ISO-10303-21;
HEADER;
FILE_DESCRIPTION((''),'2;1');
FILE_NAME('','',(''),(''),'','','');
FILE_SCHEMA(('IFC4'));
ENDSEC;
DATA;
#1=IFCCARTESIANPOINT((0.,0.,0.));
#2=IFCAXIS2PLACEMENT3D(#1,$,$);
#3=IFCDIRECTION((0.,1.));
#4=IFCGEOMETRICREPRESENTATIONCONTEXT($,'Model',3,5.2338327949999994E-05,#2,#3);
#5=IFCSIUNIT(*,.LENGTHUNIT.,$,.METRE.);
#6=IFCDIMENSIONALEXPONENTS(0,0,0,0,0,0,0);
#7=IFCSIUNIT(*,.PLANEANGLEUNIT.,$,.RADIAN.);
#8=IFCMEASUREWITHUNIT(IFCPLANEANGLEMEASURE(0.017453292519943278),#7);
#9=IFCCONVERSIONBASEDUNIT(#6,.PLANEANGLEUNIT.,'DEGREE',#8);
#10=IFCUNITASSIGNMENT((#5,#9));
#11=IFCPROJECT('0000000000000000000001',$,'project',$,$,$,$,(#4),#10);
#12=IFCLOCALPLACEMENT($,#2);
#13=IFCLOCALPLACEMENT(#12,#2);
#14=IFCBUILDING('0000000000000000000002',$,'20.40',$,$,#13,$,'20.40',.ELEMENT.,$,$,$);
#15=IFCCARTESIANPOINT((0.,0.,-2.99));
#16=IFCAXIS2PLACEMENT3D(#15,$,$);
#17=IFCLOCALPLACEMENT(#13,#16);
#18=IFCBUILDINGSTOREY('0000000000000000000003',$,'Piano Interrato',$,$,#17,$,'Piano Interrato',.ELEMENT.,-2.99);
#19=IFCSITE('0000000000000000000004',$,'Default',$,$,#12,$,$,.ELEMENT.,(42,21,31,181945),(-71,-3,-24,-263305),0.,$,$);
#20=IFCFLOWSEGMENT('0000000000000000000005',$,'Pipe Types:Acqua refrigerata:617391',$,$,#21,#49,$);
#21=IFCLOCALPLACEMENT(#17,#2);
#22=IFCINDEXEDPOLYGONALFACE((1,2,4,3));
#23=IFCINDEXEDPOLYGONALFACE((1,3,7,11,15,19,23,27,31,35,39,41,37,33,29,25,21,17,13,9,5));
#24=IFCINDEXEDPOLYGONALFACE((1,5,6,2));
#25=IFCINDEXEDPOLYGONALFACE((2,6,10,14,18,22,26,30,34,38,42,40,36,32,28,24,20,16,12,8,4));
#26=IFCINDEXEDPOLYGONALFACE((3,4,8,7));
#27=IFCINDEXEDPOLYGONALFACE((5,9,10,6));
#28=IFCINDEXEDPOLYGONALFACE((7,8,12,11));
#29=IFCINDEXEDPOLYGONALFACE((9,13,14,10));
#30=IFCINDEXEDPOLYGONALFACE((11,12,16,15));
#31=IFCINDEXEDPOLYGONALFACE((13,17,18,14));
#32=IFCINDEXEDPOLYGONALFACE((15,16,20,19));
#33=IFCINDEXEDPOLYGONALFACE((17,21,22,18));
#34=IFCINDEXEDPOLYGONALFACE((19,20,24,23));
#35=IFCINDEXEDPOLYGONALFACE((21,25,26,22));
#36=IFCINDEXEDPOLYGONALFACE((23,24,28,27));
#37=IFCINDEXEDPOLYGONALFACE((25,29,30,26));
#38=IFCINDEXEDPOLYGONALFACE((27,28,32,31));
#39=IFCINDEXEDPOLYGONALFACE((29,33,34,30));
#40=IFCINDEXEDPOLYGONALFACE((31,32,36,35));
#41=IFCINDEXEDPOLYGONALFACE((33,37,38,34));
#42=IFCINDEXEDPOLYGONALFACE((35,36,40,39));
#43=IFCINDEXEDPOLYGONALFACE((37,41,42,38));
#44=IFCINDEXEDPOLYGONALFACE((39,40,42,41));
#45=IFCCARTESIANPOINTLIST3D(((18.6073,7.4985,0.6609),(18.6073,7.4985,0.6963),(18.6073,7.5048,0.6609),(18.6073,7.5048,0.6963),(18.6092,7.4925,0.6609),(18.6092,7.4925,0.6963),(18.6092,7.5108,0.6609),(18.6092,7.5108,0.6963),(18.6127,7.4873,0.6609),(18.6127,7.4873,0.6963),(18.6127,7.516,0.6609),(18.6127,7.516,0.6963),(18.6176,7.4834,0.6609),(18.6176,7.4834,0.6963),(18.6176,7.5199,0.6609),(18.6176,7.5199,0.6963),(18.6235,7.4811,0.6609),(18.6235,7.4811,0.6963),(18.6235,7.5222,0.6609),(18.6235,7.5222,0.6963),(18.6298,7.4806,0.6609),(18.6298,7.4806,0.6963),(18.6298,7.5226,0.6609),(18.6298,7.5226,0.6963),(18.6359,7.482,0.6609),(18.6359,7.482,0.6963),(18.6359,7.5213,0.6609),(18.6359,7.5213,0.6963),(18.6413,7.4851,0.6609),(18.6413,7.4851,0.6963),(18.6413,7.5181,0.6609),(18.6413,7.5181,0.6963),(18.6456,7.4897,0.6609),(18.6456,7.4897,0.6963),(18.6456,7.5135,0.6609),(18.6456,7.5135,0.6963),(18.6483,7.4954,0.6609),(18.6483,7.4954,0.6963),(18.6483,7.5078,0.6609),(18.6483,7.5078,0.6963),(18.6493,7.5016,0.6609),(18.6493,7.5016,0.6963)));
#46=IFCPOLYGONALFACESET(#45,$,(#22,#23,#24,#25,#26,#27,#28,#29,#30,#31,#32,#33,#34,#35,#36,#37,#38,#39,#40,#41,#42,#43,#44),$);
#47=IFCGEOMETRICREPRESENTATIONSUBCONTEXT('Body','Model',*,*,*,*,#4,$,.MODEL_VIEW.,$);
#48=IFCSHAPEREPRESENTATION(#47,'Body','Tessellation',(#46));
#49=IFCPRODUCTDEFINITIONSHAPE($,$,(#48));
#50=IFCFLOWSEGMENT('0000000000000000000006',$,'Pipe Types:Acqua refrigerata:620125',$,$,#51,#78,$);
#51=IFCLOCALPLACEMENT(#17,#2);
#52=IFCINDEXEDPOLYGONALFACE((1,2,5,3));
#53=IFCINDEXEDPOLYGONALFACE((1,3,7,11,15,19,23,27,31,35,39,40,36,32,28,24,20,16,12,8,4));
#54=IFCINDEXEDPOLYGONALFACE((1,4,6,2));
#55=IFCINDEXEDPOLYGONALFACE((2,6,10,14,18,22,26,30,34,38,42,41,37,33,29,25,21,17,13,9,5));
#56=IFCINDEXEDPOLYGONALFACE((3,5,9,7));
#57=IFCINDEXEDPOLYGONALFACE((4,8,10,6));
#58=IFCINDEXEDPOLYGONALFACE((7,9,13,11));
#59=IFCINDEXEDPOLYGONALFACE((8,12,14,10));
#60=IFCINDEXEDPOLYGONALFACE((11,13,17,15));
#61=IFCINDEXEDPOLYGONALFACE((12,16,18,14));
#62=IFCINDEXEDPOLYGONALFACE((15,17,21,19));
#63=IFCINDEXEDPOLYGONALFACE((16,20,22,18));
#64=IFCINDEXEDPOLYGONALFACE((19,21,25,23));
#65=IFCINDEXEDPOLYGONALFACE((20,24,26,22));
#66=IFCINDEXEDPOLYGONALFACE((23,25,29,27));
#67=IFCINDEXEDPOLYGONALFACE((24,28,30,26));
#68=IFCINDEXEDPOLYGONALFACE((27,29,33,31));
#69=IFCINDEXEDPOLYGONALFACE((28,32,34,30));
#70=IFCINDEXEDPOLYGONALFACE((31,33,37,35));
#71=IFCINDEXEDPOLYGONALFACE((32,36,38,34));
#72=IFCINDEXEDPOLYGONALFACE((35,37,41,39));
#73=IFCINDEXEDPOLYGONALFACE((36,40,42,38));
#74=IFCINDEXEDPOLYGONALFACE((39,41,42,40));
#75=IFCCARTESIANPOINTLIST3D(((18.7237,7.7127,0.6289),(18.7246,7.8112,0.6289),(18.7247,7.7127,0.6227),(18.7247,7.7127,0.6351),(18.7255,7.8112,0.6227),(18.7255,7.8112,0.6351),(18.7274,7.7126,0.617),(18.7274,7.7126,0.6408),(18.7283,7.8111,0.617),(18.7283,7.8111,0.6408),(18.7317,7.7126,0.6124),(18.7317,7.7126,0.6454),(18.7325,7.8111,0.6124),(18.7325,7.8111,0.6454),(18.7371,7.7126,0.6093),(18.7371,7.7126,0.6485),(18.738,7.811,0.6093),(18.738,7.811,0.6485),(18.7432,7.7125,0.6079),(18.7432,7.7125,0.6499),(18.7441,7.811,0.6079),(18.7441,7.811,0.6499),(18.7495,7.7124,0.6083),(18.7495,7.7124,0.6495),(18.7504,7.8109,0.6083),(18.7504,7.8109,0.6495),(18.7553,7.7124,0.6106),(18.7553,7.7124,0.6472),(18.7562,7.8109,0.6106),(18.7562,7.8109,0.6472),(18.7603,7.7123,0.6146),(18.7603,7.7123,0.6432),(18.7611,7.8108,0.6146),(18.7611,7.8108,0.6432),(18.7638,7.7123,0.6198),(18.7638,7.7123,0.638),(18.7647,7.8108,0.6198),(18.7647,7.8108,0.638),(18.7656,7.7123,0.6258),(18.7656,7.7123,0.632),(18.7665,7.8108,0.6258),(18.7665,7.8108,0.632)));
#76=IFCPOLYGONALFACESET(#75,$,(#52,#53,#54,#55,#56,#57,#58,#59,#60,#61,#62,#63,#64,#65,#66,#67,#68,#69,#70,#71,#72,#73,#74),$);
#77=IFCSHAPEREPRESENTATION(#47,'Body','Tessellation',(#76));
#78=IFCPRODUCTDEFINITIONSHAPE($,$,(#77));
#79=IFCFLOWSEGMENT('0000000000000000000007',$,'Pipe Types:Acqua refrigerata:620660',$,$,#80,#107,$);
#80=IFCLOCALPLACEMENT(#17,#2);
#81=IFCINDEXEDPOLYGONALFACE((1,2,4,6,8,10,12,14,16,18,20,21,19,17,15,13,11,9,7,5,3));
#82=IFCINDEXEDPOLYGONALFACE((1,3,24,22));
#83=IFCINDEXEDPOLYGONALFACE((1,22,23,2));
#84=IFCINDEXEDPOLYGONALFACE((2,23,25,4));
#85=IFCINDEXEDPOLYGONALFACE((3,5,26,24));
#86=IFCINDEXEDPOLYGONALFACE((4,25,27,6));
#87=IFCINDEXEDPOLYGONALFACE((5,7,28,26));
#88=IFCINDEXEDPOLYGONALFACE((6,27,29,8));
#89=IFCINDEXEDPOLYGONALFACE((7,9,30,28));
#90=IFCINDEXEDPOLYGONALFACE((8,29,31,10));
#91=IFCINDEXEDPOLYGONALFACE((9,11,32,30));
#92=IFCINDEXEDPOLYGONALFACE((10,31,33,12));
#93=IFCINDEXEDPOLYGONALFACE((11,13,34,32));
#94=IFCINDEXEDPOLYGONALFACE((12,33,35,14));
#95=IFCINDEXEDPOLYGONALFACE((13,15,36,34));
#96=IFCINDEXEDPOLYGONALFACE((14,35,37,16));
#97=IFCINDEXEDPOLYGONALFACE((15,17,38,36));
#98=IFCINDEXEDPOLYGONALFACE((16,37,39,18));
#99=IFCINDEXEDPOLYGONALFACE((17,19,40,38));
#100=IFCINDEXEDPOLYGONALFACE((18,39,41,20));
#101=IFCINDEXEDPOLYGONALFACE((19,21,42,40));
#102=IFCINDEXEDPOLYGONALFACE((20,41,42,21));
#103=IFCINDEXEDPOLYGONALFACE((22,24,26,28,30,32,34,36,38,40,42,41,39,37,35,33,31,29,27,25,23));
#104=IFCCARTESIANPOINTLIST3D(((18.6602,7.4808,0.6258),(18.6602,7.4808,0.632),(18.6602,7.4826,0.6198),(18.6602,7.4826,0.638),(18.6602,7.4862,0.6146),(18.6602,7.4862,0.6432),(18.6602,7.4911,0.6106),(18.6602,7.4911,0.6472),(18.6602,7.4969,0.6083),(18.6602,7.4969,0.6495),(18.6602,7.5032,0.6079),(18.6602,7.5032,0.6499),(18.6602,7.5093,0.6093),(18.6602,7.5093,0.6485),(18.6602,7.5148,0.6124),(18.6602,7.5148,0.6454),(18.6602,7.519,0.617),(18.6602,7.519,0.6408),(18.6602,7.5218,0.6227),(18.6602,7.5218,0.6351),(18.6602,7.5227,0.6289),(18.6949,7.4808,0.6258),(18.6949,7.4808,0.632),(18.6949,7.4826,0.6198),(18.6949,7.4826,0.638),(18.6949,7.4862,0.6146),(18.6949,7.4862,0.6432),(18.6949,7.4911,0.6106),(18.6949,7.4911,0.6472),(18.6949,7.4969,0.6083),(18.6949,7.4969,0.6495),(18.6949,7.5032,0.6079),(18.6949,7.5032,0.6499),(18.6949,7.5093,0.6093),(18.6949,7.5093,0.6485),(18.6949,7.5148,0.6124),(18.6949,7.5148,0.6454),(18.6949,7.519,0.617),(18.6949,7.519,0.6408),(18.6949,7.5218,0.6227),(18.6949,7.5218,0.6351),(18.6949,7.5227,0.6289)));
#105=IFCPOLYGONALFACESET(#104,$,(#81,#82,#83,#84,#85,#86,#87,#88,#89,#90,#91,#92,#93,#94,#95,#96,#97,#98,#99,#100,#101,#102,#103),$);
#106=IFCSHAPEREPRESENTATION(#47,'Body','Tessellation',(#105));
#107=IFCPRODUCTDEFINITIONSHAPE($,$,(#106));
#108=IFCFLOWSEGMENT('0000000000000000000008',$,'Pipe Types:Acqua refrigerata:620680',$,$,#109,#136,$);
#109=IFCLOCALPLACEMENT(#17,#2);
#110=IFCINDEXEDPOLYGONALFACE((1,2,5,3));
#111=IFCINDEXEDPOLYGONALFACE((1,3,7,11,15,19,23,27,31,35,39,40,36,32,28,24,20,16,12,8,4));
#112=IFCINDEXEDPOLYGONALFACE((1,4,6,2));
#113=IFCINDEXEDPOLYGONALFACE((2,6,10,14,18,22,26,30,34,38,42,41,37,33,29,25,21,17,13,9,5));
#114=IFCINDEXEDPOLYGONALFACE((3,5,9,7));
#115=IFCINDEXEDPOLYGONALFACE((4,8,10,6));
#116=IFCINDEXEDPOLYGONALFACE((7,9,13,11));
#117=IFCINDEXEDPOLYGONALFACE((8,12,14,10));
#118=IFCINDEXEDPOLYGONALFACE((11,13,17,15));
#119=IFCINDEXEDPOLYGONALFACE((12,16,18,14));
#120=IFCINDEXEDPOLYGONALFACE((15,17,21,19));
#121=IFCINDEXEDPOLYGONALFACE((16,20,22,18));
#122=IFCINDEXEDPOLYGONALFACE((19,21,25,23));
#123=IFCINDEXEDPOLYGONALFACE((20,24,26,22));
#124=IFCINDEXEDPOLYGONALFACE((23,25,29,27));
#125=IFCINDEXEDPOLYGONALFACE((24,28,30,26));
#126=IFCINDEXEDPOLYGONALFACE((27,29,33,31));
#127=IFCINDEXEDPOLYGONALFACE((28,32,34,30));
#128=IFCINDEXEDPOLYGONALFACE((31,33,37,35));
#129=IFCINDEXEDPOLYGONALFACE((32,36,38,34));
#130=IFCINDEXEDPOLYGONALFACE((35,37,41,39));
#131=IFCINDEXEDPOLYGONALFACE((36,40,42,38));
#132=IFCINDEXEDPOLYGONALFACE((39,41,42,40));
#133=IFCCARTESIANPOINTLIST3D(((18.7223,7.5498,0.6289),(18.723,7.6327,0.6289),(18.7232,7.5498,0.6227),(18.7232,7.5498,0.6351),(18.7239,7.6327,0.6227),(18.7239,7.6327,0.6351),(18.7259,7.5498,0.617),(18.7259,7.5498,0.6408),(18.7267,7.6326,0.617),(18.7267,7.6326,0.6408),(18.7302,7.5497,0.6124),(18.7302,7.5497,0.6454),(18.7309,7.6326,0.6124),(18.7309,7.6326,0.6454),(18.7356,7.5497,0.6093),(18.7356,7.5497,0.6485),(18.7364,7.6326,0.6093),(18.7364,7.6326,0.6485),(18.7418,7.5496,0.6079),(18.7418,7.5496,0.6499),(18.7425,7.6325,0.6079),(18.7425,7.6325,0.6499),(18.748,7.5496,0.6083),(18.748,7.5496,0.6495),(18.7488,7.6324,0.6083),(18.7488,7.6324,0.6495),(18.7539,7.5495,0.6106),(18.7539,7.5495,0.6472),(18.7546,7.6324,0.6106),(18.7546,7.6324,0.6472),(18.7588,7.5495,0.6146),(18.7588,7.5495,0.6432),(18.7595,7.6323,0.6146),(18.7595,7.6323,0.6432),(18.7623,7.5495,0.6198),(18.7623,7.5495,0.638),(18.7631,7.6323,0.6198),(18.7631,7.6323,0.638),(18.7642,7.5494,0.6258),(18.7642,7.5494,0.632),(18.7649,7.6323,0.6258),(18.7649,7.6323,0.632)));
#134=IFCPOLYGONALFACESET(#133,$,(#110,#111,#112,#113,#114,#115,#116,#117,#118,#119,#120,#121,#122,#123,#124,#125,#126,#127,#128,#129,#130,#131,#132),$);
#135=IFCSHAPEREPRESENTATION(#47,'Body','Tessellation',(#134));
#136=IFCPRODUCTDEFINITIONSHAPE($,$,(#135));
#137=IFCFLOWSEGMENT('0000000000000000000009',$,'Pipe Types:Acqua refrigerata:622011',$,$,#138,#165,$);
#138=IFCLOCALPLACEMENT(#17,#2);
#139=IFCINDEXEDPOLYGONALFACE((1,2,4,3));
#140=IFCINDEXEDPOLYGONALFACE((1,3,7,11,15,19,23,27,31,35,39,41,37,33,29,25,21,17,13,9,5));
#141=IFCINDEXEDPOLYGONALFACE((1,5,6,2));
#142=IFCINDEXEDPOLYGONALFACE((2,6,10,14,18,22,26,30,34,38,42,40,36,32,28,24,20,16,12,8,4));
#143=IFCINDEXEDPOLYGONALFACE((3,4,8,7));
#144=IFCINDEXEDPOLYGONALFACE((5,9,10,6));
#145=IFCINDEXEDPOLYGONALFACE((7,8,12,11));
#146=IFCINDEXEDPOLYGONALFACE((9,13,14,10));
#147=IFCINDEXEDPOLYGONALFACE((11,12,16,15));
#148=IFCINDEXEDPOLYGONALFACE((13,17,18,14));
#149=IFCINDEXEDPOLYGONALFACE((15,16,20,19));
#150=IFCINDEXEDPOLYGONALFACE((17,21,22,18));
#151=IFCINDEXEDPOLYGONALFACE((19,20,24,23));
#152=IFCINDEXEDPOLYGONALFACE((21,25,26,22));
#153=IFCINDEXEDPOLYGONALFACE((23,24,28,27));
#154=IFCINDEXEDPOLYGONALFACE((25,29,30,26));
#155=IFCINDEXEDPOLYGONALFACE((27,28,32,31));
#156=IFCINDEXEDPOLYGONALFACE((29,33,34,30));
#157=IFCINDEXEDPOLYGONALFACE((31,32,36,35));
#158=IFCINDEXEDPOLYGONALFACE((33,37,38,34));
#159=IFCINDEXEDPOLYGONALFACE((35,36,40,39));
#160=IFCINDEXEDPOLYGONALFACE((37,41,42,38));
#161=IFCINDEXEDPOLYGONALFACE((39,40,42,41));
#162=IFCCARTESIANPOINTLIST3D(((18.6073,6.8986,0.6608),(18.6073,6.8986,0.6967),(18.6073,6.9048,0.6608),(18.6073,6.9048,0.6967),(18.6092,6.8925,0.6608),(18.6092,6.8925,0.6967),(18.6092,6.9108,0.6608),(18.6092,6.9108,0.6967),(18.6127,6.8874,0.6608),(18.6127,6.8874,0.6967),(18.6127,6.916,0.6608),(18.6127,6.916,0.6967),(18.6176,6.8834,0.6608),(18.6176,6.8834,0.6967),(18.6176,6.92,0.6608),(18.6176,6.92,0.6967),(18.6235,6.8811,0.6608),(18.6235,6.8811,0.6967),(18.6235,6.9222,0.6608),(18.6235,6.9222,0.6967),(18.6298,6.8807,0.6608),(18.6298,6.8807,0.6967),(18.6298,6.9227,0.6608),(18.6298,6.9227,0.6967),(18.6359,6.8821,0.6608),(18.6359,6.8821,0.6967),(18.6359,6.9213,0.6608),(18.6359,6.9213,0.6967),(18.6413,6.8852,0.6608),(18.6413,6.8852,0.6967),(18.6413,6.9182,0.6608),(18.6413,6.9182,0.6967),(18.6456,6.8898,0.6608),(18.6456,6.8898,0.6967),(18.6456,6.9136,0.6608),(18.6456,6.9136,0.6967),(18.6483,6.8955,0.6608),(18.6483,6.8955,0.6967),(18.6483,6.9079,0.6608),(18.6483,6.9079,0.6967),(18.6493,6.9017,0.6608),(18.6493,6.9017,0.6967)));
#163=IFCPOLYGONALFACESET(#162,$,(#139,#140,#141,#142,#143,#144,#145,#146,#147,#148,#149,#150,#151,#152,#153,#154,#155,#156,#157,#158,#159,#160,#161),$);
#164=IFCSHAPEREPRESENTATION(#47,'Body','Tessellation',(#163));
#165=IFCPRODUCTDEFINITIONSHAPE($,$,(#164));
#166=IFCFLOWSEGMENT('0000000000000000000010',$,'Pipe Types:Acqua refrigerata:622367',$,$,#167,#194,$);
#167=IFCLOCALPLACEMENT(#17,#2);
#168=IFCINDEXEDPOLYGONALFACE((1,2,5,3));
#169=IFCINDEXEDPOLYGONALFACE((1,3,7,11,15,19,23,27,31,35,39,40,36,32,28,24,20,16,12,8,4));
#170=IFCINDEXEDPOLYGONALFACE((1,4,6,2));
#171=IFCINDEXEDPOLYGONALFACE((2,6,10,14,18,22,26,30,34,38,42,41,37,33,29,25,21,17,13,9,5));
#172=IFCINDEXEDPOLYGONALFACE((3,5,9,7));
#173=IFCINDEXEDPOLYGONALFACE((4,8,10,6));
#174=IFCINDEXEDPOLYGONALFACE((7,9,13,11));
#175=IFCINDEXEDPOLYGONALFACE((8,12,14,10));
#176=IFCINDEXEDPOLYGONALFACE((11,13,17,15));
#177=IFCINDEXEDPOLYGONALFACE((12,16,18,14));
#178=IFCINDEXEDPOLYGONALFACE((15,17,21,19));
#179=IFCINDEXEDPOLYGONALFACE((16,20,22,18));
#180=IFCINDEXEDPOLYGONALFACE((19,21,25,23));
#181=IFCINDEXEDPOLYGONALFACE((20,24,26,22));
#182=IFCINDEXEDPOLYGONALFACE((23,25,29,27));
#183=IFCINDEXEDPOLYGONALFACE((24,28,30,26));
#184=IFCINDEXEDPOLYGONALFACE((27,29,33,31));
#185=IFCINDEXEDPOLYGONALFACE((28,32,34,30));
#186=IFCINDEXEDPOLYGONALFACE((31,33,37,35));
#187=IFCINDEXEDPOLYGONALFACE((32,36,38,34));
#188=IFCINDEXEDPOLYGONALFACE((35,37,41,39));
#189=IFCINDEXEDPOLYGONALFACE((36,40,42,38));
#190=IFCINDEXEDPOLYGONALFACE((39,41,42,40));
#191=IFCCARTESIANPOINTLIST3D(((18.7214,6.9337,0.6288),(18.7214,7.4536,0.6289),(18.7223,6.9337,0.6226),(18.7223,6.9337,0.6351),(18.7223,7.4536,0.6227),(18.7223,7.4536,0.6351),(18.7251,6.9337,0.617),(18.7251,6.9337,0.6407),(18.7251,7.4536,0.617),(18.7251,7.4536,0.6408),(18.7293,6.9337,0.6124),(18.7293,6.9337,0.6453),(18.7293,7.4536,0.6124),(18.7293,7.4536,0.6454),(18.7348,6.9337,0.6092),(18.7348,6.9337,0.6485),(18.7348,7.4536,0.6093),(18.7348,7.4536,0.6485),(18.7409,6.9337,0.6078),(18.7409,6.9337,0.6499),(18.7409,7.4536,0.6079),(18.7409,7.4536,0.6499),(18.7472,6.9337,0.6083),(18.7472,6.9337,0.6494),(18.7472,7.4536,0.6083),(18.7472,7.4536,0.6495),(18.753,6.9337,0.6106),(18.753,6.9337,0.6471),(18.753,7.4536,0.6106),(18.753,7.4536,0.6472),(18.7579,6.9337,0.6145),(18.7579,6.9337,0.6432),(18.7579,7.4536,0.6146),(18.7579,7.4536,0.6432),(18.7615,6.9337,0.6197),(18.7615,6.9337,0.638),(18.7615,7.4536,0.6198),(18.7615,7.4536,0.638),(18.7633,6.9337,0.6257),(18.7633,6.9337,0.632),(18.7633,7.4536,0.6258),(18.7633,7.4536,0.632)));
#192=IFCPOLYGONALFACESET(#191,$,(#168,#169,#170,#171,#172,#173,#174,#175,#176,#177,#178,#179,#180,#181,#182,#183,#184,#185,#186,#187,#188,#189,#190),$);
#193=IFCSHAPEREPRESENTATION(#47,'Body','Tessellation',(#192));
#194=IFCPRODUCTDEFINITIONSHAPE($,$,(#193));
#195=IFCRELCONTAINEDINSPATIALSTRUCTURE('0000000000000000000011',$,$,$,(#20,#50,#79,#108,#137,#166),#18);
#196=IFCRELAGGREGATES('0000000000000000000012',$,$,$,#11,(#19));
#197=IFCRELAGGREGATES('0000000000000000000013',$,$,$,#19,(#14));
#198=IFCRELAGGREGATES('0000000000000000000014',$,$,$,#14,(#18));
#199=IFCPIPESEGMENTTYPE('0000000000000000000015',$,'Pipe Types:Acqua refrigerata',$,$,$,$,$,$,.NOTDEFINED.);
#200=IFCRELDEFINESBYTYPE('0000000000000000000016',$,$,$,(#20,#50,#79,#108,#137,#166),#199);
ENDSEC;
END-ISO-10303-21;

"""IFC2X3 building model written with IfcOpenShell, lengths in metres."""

from ifc_helpers import new_model, entity, si_unit, converted_unit, direction, frame, frame_2d, origin, origin_2d_with_axis, place, context, subcontext, project, spatial, circle, extrude, type_object, element, save


model = new_model("IFC2X3")

# Units and contexts
model_context = context("Model", 3, precision=5.2338327949999994e-05, world=origin(), true_north=direction((0.0, 1.0)))
body_context = subcontext(model_context, "Body", "Model", "MODEL_VIEW")
ifc_project = project(units=[si_unit("LENGTHUNIT", "METRE"), converted_unit("PLANEANGLEUNIT", "DEGREE", entity("IfcPlaneAngleMeasure", 0.017453292519943278), si_unit("PLANEANGLEUNIT", "RADIAN"), dimensions=[0, 0, 0, 0, 0, 0, 0])], contexts=[model_context])

# Site, building, storey
site_placement = place(None, origin())
site = spatial("IfcSite", under=ifc_project, at=site_placement, Name="Default", CompositionType="ELEMENT", RefLatitude=(42, 21, 31, 181945), RefLongitude=(-71, -3, -24, -263305), RefElevation=0.0)
building_placement = place(site_placement, origin())
building = spatial("IfcBuilding", under=site, at=building_placement, Name="20.40", LongName="20.40", CompositionType="ELEMENT")
storey_placement = place(building_placement, frame((0.0, 0.0, -2.99)))
storey = spatial("IfcBuildingStorey", under=building, at=storey_placement, Name="Piano Interrato", LongName="Piano Interrato", CompositionType="ELEMENT", Elevation=-2.99)

# Flow segments
pipe_segment_type_1 = type_object("IfcPipeSegmentType", Name="Pipe Types:Acqua refrigerata", PredefinedType="NOTDEFINED")
flow_segment_1_placement = place(storey_placement, origin())
element("IfcFlowSegment", 1, at=flow_segment_1_placement, inside=storey, type_object=pipe_segment_type_1, Name="Pipe Types:Acqua refrigerata:617391", context=body_context, shape_type="SweptSolid", body=[
    extrude(circle(Radius=0.0211, at=origin_2d_with_axis()), frame((18.6282, 7.5016, 0.6609)), (0.0, 0.0, 1.0), 0.0354),
])
flow_segment_2_placement = place(storey_placement, origin())
element("IfcFlowSegment", 2, at=flow_segment_2_placement, inside=storey, type_object=pipe_segment_type_1, Name="Pipe Types:Acqua refrigerata:620125", context=body_context, shape_type="SweptSolid", body=[
    extrude(circle(Radius=0.0211, at=frame_2d((0.0, 0.0), x_axis=(1.0, 0.0))), frame((18.7448, 7.7125, 0.6289), z_axis=(0.009014, 0.999959, 0.0), x_axis=(-0.999959, 0.009014, 0.0)), (0.0, 0.0, 1.0), 0.0985),
])
flow_segment_3_placement = place(storey_placement, origin())
element("IfcFlowSegment", 3, at=flow_segment_3_placement, inside=storey, type_object=pipe_segment_type_1, Name="Pipe Types:Acqua refrigerata:620660", context=body_context, shape_type="SweptSolid", body=[
    extrude(circle(Radius=0.0211, at=frame_2d((0.0, 0.0), x_axis=(1.0, 0.0))), frame((18.6602, 7.5016, 0.6289), z_axis=(1.0, 0.0, 0.0), x_axis=(0.0, 1.0, 0.0)), (0.0, 0.0, 1.0), 0.0347),
])
flow_segment_4_placement = place(storey_placement, origin())
element("IfcFlowSegment", 4, at=flow_segment_4_placement, inside=storey, type_object=pipe_segment_type_1, Name="Pipe Types:Acqua refrigerata:620680", context=body_context, shape_type="SweptSolid", body=[
    extrude(circle(Radius=0.0211, at=origin_2d_with_axis()), frame((18.7433, 7.5496, 0.6289), z_axis=(0.009014, 0.999959, 0.0), x_axis=(-0.999959, 0.009014, 0.0)), (0.0, 0.0, 1.0), 0.0829),
])
flow_segment_5_placement = place(storey_placement, origin())
element("IfcFlowSegment", 5, at=flow_segment_5_placement, inside=storey, type_object=pipe_segment_type_1, Name="Pipe Types:Acqua refrigerata:622011", context=body_context, shape_type="SweptSolid", body=[
    extrude(circle(Radius=0.0211, at=origin_2d_with_axis()), frame((18.6282, 6.9017, 0.6608)), (0.0, 0.0, 1.0), 0.0358),
])
flow_segment_6_placement = place(storey_placement, origin())
element("IfcFlowSegment", 6, at=flow_segment_6_placement, inside=storey, type_object=pipe_segment_type_1, Name="Pipe Types:Acqua refrigerata:622367", context=body_context, shape_type="SweptSolid", body=[
    extrude(circle(Radius=0.0211, at=origin_2d_with_axis()), frame((18.7425, 6.9337, 0.6288), z_axis=(0.0, 1.0, 0.000103), x_axis=(-1.0, 0.0, 0.0)), (0.0, 0.0, 1.0), 0.5199),
])

save(model, "model.ifc")
